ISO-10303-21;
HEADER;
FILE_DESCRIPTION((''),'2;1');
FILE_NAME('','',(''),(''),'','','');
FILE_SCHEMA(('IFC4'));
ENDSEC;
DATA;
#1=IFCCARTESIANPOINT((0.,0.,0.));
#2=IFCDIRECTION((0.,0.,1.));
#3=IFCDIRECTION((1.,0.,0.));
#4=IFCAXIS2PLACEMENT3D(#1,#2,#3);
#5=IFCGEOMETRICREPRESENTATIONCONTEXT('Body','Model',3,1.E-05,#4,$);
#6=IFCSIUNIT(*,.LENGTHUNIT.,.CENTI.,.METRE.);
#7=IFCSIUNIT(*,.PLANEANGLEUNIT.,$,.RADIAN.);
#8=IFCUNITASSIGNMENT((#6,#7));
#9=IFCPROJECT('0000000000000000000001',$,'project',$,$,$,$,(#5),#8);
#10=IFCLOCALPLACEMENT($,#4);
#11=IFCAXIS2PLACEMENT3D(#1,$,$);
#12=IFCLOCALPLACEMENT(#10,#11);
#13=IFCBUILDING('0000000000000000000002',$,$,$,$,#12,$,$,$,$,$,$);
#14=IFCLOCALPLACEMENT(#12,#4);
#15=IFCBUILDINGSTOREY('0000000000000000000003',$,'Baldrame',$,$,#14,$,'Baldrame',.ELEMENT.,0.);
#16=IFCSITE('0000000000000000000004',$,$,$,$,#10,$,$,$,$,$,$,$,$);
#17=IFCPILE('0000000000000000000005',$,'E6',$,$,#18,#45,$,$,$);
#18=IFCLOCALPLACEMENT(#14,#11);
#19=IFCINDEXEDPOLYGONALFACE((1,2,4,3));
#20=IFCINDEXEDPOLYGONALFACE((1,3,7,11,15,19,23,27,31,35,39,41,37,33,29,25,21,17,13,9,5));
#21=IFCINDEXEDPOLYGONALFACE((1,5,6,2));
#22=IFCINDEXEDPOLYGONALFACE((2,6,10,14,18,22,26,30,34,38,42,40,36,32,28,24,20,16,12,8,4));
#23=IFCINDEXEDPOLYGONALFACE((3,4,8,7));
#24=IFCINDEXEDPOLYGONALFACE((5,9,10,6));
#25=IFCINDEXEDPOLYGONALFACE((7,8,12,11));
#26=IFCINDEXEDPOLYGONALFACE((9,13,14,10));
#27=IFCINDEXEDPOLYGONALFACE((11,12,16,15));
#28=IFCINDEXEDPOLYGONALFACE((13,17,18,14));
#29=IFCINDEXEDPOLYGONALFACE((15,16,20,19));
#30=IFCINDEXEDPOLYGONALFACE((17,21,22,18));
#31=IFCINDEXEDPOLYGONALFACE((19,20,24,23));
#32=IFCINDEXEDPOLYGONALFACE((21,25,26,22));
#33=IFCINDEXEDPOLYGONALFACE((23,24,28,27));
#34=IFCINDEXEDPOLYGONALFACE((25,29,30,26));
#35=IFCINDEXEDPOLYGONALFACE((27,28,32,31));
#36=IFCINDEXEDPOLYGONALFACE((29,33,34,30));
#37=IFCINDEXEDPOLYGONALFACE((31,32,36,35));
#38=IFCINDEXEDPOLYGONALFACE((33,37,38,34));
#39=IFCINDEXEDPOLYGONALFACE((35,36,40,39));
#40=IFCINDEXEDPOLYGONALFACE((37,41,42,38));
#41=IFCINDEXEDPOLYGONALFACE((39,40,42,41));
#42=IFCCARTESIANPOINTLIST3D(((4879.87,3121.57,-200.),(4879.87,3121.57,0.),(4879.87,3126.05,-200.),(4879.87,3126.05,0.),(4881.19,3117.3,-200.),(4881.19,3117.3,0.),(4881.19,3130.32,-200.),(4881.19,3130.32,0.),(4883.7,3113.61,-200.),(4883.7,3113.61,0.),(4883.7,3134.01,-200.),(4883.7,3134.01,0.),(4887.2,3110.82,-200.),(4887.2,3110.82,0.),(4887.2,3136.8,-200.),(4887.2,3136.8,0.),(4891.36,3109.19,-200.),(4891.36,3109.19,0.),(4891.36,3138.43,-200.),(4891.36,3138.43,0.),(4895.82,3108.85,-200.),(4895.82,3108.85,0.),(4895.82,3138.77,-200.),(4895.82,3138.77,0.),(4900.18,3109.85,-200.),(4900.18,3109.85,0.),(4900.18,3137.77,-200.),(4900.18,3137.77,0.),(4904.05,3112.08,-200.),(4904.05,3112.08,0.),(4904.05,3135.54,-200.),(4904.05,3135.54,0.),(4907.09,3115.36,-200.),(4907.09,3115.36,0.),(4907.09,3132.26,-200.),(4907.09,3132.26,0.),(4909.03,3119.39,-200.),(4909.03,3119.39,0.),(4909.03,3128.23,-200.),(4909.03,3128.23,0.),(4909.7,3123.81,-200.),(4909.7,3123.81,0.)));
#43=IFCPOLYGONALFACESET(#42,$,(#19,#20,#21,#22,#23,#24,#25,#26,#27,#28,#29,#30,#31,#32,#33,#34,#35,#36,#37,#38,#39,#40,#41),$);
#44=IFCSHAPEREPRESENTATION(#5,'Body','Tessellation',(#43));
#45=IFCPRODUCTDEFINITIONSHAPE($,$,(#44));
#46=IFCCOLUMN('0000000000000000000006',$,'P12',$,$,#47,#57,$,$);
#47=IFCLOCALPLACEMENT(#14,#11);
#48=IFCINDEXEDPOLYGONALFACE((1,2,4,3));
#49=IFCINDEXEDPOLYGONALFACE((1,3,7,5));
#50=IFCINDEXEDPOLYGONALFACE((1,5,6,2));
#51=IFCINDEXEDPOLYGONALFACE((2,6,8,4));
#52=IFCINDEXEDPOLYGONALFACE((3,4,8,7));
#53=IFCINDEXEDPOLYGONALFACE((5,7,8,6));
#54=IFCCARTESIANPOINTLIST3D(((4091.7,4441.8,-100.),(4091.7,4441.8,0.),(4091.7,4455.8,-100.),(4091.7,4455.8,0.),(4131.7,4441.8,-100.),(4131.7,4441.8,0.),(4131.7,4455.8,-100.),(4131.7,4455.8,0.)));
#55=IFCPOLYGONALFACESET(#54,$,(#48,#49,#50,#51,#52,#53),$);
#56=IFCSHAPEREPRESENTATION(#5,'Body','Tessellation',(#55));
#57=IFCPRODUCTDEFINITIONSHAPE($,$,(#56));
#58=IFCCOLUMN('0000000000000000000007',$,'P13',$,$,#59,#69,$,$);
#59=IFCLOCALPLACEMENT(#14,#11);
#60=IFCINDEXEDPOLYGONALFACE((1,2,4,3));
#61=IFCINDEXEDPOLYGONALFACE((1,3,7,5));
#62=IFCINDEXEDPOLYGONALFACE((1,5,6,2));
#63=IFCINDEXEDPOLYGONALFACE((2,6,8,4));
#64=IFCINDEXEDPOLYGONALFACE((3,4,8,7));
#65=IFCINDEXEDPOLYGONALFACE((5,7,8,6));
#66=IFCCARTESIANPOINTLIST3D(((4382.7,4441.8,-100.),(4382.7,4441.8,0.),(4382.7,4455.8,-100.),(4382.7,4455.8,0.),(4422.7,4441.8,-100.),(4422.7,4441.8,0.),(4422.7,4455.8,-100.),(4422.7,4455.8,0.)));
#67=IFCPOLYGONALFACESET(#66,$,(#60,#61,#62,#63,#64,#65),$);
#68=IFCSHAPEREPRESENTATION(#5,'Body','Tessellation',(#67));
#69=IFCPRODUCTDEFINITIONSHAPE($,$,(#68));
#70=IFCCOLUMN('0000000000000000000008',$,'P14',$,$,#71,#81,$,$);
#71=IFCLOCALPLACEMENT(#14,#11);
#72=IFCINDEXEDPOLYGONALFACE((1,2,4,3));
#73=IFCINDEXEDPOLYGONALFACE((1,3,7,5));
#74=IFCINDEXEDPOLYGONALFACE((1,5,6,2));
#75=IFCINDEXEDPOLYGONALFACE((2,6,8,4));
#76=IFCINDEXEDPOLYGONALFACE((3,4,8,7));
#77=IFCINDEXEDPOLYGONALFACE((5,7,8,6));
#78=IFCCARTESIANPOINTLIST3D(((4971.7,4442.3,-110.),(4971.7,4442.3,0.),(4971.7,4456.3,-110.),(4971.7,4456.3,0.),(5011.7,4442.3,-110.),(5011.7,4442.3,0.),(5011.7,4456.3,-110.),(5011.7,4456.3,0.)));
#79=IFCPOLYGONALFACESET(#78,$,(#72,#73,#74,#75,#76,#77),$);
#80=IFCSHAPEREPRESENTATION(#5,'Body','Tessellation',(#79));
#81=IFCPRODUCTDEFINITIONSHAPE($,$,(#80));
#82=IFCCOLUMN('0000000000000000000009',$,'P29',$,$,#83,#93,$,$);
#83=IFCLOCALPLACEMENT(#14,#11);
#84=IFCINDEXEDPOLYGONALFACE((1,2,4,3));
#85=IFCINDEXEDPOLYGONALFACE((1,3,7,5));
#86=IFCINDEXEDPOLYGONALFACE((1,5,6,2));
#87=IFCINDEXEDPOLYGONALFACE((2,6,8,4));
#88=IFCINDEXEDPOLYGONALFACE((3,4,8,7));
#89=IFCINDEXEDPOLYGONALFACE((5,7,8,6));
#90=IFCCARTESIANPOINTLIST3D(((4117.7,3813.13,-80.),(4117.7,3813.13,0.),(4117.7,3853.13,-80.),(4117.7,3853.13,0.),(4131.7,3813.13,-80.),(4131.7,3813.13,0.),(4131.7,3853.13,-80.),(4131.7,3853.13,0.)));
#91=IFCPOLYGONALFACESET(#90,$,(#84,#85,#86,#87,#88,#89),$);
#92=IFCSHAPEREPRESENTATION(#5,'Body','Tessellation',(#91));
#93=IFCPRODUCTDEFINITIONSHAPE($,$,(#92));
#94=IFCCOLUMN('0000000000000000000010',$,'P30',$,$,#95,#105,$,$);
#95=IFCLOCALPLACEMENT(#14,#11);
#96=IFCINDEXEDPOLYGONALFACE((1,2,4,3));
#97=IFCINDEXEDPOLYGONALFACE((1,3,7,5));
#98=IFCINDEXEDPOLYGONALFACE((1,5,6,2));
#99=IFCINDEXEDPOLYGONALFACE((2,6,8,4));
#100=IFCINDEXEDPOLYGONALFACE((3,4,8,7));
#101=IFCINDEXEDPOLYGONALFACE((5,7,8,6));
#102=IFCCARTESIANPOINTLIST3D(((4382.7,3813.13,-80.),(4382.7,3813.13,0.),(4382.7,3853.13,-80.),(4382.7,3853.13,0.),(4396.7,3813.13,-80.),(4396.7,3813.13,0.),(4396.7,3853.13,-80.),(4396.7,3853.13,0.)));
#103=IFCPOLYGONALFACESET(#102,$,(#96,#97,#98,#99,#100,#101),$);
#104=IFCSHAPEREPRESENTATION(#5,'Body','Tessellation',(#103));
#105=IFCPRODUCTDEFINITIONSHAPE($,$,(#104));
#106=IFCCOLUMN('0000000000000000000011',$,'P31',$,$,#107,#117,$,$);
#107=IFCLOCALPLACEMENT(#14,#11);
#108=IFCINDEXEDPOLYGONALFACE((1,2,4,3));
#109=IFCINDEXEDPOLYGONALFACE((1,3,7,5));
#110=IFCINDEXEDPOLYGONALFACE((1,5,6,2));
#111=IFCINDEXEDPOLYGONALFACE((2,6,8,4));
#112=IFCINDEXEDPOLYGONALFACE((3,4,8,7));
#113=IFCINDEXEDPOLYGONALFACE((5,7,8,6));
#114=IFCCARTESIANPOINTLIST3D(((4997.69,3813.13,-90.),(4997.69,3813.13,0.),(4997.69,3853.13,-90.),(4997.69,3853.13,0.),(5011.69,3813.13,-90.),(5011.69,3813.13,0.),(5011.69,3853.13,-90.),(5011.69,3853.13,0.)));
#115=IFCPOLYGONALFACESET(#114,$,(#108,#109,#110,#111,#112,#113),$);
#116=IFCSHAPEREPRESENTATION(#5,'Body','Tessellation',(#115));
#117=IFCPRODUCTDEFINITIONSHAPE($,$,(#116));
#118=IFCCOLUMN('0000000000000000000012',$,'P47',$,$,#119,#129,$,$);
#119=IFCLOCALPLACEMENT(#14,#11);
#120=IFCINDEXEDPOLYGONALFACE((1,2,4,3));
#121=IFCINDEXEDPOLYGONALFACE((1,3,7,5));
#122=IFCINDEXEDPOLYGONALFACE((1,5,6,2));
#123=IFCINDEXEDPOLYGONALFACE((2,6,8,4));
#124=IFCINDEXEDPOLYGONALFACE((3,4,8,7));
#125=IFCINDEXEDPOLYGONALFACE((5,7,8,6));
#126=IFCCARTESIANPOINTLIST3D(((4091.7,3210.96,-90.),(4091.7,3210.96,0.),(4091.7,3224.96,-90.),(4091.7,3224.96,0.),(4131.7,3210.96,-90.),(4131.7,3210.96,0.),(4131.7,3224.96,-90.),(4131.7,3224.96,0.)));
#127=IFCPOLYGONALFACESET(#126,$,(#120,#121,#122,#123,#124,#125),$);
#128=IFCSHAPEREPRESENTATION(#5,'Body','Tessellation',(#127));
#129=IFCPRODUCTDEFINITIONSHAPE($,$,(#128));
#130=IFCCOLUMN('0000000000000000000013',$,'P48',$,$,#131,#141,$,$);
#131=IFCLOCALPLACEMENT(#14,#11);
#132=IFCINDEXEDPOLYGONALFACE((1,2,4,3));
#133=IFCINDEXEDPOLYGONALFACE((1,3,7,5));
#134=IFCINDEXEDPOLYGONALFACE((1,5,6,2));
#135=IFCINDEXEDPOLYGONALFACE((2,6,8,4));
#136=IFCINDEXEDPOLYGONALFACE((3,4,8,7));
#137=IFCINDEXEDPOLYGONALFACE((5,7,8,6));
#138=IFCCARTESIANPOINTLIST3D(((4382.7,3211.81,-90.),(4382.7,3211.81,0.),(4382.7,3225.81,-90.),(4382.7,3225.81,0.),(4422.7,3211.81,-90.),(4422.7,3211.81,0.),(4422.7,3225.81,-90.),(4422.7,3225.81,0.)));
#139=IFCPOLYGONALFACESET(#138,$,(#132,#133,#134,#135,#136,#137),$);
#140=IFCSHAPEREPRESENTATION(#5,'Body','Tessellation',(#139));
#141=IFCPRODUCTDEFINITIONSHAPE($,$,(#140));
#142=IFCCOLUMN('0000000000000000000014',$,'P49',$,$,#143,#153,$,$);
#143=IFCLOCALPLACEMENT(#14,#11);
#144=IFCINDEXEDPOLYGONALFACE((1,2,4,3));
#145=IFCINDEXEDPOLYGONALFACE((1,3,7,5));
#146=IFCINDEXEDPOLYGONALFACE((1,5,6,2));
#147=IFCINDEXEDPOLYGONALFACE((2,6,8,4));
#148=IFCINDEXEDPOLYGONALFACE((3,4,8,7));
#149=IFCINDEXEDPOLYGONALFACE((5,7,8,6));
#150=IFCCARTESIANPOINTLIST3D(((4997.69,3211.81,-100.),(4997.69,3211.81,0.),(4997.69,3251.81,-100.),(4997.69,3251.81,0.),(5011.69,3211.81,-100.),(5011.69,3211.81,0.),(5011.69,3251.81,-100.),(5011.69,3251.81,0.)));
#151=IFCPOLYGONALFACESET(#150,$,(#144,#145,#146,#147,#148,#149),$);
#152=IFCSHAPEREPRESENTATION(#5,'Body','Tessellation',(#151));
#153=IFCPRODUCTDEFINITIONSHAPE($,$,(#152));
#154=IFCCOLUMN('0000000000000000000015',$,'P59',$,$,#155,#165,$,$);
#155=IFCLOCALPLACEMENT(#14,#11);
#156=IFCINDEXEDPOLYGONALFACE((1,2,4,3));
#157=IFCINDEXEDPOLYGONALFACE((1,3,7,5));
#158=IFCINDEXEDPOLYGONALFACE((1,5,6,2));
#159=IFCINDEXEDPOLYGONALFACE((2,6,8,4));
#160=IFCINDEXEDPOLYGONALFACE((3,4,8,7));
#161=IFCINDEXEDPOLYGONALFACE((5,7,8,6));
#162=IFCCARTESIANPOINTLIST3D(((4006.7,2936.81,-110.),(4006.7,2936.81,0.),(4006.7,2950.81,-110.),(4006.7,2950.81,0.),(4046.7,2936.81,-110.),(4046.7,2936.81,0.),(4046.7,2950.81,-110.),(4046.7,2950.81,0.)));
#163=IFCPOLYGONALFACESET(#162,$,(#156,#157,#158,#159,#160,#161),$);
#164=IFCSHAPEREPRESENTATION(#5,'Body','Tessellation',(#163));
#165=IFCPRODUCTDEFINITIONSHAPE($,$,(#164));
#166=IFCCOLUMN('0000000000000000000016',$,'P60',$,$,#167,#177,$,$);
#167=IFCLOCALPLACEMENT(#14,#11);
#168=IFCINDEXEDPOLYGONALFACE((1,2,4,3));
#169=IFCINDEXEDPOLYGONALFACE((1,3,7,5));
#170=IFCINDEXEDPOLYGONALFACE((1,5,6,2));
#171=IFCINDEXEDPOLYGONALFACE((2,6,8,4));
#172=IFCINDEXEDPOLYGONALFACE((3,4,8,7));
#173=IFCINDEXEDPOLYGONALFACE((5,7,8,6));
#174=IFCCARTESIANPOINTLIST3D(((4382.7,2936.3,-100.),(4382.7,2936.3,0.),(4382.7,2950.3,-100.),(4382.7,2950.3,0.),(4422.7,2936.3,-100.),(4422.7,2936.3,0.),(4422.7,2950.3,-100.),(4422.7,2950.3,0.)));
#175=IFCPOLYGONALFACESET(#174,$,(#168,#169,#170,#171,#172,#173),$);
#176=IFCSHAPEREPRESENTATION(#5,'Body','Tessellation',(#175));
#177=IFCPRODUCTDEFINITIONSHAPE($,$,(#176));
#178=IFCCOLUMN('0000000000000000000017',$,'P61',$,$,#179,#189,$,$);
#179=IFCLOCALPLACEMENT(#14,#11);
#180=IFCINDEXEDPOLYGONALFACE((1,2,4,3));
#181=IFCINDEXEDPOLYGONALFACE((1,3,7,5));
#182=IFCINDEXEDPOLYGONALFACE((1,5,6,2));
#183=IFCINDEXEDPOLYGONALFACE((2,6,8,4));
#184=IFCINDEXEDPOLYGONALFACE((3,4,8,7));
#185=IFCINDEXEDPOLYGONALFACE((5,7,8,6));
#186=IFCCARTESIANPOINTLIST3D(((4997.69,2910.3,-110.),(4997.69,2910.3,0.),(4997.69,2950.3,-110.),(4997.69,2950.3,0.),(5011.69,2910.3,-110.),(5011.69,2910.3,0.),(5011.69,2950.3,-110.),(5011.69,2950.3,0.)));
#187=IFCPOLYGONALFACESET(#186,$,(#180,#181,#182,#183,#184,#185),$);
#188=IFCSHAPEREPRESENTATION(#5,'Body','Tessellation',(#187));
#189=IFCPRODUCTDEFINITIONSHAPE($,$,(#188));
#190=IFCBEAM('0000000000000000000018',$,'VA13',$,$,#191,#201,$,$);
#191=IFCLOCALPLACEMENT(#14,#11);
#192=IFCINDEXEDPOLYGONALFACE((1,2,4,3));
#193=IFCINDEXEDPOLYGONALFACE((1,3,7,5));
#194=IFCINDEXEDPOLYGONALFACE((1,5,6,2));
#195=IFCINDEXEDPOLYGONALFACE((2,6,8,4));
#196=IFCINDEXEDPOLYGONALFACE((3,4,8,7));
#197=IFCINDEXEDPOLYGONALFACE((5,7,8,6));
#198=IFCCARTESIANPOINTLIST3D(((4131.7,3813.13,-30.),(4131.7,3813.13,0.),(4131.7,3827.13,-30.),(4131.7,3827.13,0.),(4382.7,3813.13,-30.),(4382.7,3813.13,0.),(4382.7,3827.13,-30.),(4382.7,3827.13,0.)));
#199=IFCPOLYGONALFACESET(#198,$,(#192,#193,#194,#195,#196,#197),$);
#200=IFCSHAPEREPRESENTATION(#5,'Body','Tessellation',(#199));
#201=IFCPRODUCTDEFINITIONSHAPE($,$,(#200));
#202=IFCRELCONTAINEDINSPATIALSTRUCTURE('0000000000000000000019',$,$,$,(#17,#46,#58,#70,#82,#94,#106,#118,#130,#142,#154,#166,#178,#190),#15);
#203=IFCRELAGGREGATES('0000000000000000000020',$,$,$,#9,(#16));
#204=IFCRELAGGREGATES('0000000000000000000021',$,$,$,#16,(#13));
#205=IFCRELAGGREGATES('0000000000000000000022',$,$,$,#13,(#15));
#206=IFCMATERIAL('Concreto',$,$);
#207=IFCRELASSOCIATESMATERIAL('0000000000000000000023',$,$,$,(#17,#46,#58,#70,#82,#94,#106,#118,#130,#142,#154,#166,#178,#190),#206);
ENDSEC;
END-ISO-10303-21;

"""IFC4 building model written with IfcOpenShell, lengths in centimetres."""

from ifc_helpers import new_model, si_unit, frame, origin, origin_with_axes, origin_2d_with_axis, place, context, project, spatial, rectangle, circle, extrude, material, element, save


model = new_model("IFC4")

# Units and contexts
model_context = context("Model", 3, precision=1e-05, world=origin_with_axes(), identifier="Body")
ifc_project = project(units=[si_unit("LENGTHUNIT", "METRE", prefix="CENTI"), si_unit("PLANEANGLEUNIT", "RADIAN")], contexts=[model_context])

# Site, building, storey
site_placement = place(None, origin_with_axes())
site = spatial("IfcSite", under=ifc_project, at=site_placement)
building_placement = place(site_placement, origin())
building = spatial("IfcBuilding", under=site, at=building_placement)
storey_placement = place(building_placement, origin_with_axes())
storey = spatial("IfcBuildingStorey", under=building, at=storey_placement, Name="Baldrame", LongName="Baldrame", CompositionType="ELEMENT", Elevation=0.0)

# Pile
ifc_material = material(Name="Concreto")
pile_placement = place(storey_placement, frame((4894.7, 3123.81, 0.0), z_axis=(0.0, 0.0, 1.0), x_axis=(1.0, 0.0, 0.0)))
element("IfcPile", 1, at=pile_placement, inside=storey, material=ifc_material, Name="E6", context=model_context, shape_type="SolidModel", body=[
    extrude(circle(Radius=15.0, at=origin_2d_with_axis()), frame((0.0, 0.0, -200.0), z_axis=(0.0, 0.0, 1.0), x_axis=(1.0, 0.0, 0.0)), (0.0, 0.0, 1.0), 200.0),
])

# Columns
for number, where, z_axis, x_axis, name in (
    (2, (4111.7, 4448.8, 0.0), (0.0, 0.0, 1.0), (1.0, 0.0, 0.0), "P12"),
    (3, (4402.7, 4448.8, 0.0), (0.0, 0.0, 1.0), (1.0, 0.0, 0.0), "P13"),
):
    element("IfcColumn", number, at=place(storey_placement, frame(where, z_axis=z_axis, x_axis=x_axis)), inside=storey, material=ifc_material, Name=name, context=model_context, shape_type="SolidModel", body=[
        extrude(rectangle(XDim=14.0, YDim=40.0, at=origin_2d_with_axis()), frame((0.0, 0.0, -100.0), z_axis=(0.0, 0.0, 1.0), x_axis=(0.0, -1.0, 0.0)), (0.0, 0.0, 1.0), 100.0),
    ])
column_1_placement = place(storey_placement, frame((4991.7, 4449.3, 0.0), z_axis=(0.0, 0.0, 1.0), x_axis=(1.0, 0.0, 0.0)))
element("IfcColumn", 4, at=column_1_placement, inside=storey, material=ifc_material, Name="P14", context=model_context, shape_type="SolidModel", body=[
    extrude(rectangle(XDim=14.0, YDim=40.0, at=origin_2d_with_axis()), frame((0.0, 0.0, -110.0), z_axis=(0.0, 0.0, 1.0), x_axis=(0.0, 1.0, 0.0)), (0.0, 0.0, 1.0), 110.0),
])
for number, where, z_axis, x_axis, name in (
    (5, (4124.7, 3833.13, 0.0), (0.0, 0.0, 1.0), (1.0, 0.0, 0.0), "P29"),
    (6, (4389.7, 3833.13, 0.0), (0.0, 0.0, 1.0), (1.0, 0.0, 0.0), "P30"),
):
    element("IfcColumn", number, at=place(storey_placement, frame(where, z_axis=z_axis, x_axis=x_axis)), inside=storey, material=ifc_material, Name=name, context=model_context, shape_type="SolidModel", body=[
        extrude(rectangle(XDim=14.0, YDim=40.0, at=origin_2d_with_axis()), frame((0.0, 0.0, -80.0), z_axis=(0.0, 0.0, 1.0), x_axis=(1.0, 0.0, 0.0)), (0.0, 0.0, 1.0), 80.0),
    ])
column_2_placement = place(storey_placement, frame((5004.69, 3833.13, 0.0), z_axis=(0.0, 0.0, 1.0), x_axis=(1.0, 0.0, 0.0)))
element("IfcColumn", 7, at=column_2_placement, inside=storey, material=ifc_material, Name="P31", context=model_context, shape_type="SolidModel", body=[
    extrude(rectangle(XDim=14.0, YDim=40.0, at=origin_2d_with_axis()), frame((0.0, 0.0, -90.0), z_axis=(0.0, 0.0, 1.0), x_axis=(1.0, 0.0, 0.0)), (0.0, 0.0, 1.0), 90.0),
])
for number, where, z_axis, x_axis, name in (
    (8, (4111.7, 3217.96, 0.0), (0.0, 0.0, 1.0), (1.0, 0.0, 0.0), "P47"),
    (9, (4402.7, 3218.81, 0.0), (0.0, 0.0, 1.0), (1.0, 0.0, 0.0), "P48"),
):
    element("IfcColumn", number, at=place(storey_placement, frame(where, z_axis=z_axis, x_axis=x_axis)), inside=storey, material=ifc_material, Name=name, context=model_context, shape_type="SolidModel", body=[
        extrude(rectangle(XDim=14.0, YDim=40.0, at=origin_2d_with_axis()), frame((0.0, 0.0, -90.0), z_axis=(0.0, 0.0, 1.0), x_axis=(0.0, -1.0, 0.0)), (0.0, 0.0, 1.0), 90.0),
    ])
column_3_placement = place(storey_placement, frame((5004.69, 3231.81, 0.0), z_axis=(0.0, 0.0, 1.0), x_axis=(1.0, 0.0, 0.0)))
element("IfcColumn", 10, at=column_3_placement, inside=storey, material=ifc_material, Name="P49", context=model_context, shape_type="SolidModel", body=[
    extrude(rectangle(XDim=14.0, YDim=40.0, at=origin_2d_with_axis()), frame((0.0, 0.0, -100.0), z_axis=(0.0, 0.0, 1.0), x_axis=(1.0, 0.0, 0.0)), (0.0, 0.0, 1.0), 100.0),
])
column_4_placement = place(storey_placement, frame((4026.7, 2943.81, 0.0), z_axis=(0.0, 0.0, 1.0), x_axis=(1.0, 0.0, 0.0)))
element("IfcColumn", 11, at=column_4_placement, inside=storey, material=ifc_material, Name="P59", context=model_context, shape_type="SolidModel", body=[
    extrude(rectangle(XDim=14.0, YDim=40.0, at=origin_2d_with_axis()), frame((0.0, 0.0, -110.0), z_axis=(0.0, 0.0, 1.0), x_axis=(0.0, -1.0, 0.0)), (0.0, 0.0, 1.0), 110.0),
])
column_5_placement = place(storey_placement, frame((4402.7, 2943.3, 0.0), z_axis=(0.0, 0.0, 1.0), x_axis=(1.0, 0.0, 0.0)))
element("IfcColumn", 12, at=column_5_placement, inside=storey, material=ifc_material, Name="P60", context=model_context, shape_type="SolidModel", body=[
    extrude(rectangle(XDim=14.0, YDim=40.0, at=origin_2d_with_axis()), frame((0.0, 0.0, -100.0), z_axis=(0.0, 0.0, 1.0), x_axis=(0.0, -1.0, 0.0)), (0.0, 0.0, 1.0), 100.0),
])
column_6_placement = place(storey_placement, frame((5004.69, 2930.3, 0.0), z_axis=(0.0, 0.0, 1.0), x_axis=(1.0, 0.0, 0.0)))
element("IfcColumn", 13, at=column_6_placement, inside=storey, material=ifc_material, Name="P61", context=model_context, shape_type="SolidModel", body=[
    extrude(rectangle(XDim=14.0, YDim=40.0, at=origin_2d_with_axis()), frame((0.0, 0.0, -110.0), z_axis=(0.0, 0.0, 1.0), x_axis=(1.0, 0.0, 0.0)), (0.0, 0.0, 1.0), 110.0),
])

# Beam
beam_1_placement = place(storey_placement, frame((4257.2, 3820.13, 0.0), z_axis=(0.0, 0.0, 1.0), x_axis=(1.0, 0.0, 0.0)))
element("IfcBeam", 14, at=beam_1_placement, inside=storey, material=ifc_material, Name="VA13", context=model_context, shape_type="SolidModel", body=[
    extrude(rectangle(XDim=14.0, YDim=30.0, at=origin_2d_with_axis()), frame((-125.5, 0.0, -15.0), z_axis=(1.0, 0.0, 0.0), x_axis=(0.0, 1.0, 0.0)), (0.0, 0.0, 1.0), 251.0),
])

save(model, "model.ifc")
